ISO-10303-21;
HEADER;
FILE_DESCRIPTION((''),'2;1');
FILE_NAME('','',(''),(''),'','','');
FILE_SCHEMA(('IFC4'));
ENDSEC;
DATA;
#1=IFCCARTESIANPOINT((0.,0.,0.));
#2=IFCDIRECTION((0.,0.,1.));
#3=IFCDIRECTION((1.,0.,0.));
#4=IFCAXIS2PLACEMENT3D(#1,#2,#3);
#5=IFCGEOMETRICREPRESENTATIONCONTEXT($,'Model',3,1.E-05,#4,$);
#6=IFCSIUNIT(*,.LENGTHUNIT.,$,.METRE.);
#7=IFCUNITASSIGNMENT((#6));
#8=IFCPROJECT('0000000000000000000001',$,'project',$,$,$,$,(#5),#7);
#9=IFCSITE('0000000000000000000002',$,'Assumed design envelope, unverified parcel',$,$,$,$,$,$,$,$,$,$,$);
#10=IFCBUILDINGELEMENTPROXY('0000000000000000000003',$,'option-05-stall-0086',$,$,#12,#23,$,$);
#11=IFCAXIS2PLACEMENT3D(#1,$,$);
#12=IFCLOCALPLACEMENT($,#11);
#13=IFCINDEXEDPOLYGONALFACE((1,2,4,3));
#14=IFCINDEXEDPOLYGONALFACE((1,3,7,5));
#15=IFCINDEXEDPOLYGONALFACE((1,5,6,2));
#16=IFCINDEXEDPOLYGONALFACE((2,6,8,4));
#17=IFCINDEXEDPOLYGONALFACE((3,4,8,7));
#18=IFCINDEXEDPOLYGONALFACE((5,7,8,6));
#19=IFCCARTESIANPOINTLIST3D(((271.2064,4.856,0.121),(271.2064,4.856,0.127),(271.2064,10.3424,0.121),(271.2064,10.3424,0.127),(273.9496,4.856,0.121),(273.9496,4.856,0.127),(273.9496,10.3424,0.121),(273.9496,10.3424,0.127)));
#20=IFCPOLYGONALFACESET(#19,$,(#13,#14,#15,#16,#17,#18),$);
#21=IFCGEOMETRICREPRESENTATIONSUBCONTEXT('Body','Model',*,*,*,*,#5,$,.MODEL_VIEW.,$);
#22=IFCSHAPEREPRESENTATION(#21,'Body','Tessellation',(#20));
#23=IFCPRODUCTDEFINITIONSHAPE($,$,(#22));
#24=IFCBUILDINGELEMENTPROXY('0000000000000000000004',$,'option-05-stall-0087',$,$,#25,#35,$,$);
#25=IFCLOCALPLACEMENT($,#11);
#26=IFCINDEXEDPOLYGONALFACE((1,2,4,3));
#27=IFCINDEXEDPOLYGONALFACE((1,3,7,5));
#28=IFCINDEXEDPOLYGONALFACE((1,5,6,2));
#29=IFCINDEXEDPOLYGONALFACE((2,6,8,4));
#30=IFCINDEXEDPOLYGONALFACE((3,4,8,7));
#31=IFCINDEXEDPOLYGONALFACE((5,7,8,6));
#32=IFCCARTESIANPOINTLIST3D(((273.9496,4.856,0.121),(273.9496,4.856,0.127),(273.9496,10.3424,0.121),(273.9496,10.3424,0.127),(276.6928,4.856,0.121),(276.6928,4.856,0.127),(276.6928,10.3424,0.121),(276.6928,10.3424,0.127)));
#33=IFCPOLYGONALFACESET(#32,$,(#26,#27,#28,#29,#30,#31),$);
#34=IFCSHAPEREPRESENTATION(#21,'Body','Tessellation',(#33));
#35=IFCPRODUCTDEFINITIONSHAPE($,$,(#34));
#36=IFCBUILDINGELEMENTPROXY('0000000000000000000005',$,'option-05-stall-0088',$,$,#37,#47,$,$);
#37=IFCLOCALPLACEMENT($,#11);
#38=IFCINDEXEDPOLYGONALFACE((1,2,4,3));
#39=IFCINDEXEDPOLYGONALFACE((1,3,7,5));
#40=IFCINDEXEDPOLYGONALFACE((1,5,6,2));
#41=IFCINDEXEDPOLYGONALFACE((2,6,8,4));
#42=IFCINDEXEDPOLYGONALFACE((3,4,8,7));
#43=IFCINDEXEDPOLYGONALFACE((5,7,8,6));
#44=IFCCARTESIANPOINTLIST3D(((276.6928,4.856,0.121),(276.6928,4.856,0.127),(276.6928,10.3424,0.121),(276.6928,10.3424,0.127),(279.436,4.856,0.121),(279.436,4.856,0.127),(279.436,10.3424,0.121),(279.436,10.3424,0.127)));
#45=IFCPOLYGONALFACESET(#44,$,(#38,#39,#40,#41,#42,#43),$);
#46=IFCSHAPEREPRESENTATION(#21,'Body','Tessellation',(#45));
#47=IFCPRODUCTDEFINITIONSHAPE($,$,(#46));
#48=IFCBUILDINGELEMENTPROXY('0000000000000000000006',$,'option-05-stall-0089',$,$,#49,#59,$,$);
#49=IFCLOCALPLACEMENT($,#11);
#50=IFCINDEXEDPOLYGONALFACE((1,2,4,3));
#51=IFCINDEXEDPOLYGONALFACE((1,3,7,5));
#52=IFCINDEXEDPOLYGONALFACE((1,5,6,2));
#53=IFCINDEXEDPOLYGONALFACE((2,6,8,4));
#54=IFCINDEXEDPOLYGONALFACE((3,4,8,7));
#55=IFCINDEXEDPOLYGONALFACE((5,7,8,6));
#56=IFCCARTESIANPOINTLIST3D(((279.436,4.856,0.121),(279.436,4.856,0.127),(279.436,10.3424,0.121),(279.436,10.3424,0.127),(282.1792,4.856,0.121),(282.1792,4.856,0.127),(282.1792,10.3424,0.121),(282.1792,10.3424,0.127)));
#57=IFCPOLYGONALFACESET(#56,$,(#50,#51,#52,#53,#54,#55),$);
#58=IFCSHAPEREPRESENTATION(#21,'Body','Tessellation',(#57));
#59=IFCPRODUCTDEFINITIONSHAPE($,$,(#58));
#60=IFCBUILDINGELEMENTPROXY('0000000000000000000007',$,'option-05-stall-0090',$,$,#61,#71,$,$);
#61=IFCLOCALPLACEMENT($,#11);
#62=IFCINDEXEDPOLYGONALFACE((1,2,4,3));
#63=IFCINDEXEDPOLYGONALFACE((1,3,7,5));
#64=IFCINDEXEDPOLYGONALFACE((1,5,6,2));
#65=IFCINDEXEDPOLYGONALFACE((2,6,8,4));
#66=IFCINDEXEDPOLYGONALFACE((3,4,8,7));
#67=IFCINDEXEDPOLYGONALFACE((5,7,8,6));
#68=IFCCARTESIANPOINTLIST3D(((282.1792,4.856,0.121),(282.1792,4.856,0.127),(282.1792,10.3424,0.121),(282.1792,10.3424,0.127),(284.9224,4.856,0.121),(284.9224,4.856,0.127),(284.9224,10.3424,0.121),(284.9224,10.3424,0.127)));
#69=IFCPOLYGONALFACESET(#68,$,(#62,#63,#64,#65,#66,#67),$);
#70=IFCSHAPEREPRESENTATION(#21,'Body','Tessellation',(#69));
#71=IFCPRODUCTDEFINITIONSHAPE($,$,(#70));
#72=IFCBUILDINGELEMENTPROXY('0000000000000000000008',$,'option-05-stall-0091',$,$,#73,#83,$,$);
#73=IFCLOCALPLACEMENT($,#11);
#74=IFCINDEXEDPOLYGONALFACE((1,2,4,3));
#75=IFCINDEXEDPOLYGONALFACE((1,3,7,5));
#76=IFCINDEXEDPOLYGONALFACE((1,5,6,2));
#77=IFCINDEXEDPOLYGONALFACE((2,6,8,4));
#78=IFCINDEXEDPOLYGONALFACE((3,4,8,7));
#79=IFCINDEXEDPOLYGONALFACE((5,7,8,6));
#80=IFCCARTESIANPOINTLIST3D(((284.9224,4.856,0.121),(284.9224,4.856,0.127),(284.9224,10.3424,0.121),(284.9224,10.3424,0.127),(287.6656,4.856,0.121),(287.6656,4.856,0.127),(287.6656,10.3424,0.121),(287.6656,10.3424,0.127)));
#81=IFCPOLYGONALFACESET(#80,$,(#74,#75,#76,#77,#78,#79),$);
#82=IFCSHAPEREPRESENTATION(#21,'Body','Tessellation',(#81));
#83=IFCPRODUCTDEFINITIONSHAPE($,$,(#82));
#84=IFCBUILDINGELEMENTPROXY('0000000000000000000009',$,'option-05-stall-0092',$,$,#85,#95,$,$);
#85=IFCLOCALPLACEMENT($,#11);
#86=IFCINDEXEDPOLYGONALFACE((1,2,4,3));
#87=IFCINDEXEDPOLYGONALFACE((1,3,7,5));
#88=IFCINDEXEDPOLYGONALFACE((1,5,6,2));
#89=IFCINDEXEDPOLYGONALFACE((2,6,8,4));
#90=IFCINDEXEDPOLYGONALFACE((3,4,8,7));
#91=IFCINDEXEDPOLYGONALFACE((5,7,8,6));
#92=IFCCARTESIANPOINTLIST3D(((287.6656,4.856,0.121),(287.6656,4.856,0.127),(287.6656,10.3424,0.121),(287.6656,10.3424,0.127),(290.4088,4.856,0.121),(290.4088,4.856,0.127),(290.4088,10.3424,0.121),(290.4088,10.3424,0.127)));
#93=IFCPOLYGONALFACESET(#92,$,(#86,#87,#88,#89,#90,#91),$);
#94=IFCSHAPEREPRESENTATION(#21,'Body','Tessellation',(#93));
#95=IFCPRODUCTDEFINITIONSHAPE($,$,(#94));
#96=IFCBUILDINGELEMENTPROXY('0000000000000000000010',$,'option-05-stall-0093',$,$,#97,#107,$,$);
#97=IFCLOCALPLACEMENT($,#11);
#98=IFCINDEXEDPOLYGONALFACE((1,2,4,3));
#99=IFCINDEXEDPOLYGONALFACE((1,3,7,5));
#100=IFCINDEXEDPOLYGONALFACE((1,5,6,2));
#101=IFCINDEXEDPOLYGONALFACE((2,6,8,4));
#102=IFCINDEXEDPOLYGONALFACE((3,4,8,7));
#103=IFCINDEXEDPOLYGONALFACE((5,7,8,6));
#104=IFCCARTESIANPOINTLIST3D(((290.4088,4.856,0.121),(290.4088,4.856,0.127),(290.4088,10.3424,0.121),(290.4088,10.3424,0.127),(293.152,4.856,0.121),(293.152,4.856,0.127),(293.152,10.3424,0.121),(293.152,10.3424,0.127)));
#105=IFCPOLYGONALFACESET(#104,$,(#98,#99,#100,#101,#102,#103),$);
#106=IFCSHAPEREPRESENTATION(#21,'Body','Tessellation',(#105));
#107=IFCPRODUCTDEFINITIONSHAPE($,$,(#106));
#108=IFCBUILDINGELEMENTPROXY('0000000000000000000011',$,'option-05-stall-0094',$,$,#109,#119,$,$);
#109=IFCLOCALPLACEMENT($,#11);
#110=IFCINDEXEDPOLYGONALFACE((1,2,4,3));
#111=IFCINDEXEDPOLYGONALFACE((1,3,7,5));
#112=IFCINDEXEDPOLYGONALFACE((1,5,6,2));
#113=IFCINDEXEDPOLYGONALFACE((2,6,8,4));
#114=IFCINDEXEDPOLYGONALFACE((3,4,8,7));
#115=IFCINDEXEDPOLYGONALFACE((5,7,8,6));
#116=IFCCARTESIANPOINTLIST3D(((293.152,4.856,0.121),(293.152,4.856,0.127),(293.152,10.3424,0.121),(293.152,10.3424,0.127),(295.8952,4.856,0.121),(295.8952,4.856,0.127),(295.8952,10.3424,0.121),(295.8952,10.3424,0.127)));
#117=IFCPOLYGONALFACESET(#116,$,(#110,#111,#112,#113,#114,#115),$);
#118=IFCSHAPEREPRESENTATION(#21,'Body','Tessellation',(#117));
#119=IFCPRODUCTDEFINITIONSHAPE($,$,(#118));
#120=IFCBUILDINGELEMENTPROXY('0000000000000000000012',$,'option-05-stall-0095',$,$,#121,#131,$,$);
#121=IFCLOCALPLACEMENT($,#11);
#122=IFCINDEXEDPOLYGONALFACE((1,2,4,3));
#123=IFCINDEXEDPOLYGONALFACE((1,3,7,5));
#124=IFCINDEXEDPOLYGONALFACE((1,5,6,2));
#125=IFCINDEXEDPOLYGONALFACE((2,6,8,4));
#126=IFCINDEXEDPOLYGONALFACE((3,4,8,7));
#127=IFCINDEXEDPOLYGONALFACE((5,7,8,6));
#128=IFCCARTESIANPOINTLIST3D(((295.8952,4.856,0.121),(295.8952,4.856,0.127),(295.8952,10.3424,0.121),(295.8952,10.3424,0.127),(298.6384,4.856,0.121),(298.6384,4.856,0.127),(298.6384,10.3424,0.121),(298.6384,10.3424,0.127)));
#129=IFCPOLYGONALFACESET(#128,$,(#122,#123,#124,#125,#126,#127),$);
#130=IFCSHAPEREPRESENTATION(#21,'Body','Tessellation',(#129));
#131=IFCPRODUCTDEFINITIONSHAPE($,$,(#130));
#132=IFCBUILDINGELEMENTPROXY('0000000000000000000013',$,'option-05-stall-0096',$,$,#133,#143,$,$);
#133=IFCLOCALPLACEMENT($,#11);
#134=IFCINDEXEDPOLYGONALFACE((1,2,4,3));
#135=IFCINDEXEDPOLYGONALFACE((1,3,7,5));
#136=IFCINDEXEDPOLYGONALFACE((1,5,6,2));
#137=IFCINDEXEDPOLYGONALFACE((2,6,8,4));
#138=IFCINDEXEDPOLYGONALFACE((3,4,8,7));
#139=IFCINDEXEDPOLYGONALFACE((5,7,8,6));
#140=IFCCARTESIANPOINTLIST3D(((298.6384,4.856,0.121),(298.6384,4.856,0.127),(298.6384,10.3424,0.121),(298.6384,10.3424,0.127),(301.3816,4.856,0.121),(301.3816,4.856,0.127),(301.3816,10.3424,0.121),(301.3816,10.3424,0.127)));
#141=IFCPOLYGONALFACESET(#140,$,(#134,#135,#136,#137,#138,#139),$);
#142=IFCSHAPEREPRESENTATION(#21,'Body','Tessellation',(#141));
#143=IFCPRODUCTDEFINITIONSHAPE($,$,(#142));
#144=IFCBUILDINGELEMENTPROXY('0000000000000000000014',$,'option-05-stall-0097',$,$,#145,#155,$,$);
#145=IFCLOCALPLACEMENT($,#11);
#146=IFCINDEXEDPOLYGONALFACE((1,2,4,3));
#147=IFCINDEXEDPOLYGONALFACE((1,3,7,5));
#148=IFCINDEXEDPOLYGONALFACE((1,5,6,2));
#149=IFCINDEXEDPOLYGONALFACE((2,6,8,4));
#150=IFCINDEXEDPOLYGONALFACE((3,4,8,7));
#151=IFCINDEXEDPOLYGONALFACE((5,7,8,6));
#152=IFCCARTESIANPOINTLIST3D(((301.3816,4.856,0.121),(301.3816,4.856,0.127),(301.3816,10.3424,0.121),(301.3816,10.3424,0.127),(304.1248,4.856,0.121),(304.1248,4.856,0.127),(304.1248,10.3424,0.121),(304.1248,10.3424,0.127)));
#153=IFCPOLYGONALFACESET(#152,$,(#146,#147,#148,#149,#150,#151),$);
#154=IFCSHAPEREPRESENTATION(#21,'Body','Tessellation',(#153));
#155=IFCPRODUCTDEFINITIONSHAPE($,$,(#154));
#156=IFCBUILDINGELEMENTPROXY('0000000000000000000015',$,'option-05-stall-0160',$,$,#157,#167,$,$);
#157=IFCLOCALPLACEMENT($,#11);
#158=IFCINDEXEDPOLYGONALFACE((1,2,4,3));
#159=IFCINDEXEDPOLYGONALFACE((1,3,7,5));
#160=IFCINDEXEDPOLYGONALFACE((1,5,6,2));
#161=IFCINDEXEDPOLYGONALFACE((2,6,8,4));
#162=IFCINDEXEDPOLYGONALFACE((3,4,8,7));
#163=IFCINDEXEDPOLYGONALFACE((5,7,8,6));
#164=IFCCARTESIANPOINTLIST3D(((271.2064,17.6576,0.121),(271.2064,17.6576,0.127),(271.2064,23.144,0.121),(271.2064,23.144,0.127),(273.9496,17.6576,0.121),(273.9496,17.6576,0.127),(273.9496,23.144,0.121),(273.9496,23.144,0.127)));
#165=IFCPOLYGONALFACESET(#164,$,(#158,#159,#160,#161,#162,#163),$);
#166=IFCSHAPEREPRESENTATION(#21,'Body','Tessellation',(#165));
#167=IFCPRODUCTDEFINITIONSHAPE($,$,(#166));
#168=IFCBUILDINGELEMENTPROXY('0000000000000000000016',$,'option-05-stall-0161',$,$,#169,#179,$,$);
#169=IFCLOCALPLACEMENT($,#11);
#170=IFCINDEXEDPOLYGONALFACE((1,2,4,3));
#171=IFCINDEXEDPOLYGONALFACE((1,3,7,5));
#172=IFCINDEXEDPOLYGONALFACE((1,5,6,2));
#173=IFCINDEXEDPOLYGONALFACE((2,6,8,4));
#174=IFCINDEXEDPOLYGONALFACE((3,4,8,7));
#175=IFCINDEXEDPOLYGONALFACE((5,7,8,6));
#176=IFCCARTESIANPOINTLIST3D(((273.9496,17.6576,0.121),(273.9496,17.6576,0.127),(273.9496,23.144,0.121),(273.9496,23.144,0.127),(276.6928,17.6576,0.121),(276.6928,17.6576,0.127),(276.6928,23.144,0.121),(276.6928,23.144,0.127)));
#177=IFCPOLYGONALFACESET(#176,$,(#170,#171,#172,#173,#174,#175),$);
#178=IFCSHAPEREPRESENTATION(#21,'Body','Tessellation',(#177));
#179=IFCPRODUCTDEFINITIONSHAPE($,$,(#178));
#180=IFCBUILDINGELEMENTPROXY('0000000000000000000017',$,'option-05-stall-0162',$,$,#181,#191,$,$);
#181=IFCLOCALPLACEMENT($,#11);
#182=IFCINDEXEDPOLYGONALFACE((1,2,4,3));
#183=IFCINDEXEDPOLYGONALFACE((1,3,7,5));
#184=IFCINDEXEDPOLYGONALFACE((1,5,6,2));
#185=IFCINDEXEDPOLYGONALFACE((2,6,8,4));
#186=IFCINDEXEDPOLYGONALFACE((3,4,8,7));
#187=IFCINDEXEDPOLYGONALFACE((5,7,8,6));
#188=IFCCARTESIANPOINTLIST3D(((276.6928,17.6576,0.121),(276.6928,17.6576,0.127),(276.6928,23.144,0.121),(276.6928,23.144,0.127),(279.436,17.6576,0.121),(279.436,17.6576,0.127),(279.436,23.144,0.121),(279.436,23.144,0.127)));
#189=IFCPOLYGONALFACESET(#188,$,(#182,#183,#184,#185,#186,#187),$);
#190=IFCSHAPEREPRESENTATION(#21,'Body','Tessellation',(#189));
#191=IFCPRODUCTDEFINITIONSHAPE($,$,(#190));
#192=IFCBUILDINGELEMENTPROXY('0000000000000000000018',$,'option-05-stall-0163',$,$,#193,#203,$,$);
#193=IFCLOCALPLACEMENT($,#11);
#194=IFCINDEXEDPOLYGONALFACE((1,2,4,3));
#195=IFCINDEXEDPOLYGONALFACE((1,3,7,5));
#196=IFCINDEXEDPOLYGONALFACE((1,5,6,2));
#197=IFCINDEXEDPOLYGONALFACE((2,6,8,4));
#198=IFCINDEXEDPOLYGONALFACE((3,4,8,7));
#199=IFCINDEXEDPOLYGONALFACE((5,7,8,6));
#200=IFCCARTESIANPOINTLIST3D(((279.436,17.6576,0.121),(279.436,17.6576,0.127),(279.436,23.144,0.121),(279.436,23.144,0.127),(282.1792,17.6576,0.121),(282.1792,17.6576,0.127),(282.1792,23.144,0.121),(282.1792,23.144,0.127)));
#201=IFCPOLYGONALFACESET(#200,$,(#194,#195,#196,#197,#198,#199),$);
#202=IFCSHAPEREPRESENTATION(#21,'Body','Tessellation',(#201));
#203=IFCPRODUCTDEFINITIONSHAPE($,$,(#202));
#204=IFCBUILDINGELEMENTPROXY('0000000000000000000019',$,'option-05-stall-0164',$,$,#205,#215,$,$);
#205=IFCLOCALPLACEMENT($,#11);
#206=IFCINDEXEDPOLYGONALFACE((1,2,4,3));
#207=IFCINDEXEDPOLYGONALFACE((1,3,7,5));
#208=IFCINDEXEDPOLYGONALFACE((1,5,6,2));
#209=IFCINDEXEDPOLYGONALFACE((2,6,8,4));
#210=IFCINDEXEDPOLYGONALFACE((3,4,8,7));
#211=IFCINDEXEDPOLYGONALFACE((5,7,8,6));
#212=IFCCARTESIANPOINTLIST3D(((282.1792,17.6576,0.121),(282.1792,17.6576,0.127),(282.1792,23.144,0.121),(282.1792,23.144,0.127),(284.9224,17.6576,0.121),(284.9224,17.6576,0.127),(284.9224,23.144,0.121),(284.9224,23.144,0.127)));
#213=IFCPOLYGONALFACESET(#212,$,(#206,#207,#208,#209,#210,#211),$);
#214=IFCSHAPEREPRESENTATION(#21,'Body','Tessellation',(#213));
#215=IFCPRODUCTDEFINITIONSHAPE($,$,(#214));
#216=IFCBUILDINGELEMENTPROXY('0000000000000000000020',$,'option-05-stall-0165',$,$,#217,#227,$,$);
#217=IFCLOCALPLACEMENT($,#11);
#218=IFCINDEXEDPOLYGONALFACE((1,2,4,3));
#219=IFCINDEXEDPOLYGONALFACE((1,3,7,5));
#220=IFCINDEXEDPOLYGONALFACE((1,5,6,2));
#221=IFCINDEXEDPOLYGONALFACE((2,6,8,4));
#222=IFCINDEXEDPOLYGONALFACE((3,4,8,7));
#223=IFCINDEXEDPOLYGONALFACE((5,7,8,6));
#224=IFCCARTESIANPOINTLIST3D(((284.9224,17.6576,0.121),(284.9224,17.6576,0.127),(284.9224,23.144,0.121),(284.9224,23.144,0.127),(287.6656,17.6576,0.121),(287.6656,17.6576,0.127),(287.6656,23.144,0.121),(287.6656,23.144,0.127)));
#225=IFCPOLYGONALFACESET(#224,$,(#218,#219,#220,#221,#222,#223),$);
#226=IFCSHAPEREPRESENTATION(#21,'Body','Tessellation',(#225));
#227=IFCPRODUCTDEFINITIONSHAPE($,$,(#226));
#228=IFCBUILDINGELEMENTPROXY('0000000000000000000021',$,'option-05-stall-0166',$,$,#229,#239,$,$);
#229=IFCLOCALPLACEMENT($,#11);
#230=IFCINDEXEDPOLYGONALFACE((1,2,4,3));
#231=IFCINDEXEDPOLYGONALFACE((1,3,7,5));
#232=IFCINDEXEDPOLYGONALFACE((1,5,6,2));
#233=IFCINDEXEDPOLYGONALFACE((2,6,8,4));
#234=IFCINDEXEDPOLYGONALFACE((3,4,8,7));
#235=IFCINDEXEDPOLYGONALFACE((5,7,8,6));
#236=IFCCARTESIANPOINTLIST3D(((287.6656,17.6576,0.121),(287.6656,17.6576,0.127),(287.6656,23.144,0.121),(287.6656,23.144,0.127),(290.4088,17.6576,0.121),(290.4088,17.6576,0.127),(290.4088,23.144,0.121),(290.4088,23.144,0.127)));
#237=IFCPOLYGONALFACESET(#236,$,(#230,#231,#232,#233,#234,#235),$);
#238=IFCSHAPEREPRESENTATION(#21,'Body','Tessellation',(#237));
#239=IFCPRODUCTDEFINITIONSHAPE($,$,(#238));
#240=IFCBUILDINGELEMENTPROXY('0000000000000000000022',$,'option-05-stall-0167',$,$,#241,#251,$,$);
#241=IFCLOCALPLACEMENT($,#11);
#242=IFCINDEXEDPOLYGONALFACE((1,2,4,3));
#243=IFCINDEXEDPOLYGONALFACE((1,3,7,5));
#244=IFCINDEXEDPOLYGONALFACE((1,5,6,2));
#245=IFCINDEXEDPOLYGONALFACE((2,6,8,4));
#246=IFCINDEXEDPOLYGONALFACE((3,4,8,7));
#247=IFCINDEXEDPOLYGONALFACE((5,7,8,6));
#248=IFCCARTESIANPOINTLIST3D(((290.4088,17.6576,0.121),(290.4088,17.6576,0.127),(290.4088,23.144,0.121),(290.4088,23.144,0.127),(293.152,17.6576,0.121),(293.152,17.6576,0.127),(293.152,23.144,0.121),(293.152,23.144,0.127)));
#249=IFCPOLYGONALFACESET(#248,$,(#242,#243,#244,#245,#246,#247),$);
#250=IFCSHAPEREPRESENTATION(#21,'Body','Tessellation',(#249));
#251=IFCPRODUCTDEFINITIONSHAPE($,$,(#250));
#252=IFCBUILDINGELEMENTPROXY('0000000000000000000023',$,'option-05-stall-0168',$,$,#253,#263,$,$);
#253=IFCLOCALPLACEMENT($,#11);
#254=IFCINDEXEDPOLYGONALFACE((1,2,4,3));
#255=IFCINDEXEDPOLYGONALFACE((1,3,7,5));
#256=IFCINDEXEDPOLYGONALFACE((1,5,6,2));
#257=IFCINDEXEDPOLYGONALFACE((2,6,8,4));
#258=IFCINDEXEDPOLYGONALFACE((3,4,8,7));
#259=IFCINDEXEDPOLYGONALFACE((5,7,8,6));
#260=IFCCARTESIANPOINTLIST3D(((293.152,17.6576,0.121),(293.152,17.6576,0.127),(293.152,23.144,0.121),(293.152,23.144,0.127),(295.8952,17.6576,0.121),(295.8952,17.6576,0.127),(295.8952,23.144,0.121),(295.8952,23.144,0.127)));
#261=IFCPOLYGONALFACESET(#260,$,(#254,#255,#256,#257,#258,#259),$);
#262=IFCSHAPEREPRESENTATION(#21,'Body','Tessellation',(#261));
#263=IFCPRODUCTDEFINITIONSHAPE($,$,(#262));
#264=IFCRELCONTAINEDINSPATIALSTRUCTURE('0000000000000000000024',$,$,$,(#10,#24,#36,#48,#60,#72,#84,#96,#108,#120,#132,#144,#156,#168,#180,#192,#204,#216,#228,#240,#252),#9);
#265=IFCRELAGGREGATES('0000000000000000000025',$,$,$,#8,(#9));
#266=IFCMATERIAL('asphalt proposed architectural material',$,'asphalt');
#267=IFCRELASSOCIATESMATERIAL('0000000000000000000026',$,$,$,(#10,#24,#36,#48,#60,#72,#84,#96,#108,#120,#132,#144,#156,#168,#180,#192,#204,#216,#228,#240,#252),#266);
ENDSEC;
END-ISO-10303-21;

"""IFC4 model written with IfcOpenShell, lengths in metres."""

from ifc_helpers import new_model, si_unit, frame, origin_with_axes, place, context, subcontext, project, spatial, rectangle, extrude, material, element, save


model = new_model("IFC4")

# Units and contexts
model_context = context("Model", 3, precision=1e-05, world=origin_with_axes())
body_context = subcontext(model_context, "Body", "Model", "MODEL_VIEW")
ifc_project = project(units=[si_unit("LENGTHUNIT", "METRE")], contexts=[model_context])

# Site
site = spatial("IfcSite", under=ifc_project, Name="Assumed design envelope, unverified parcel")

# Building element proxies
ifc_material = material(Name="asphalt proposed architectural material", Category="asphalt")
for number, where, z_axis, x_axis, name in (
    (1, (272.578, 7.5992, 0.121), (0.0, 0.0, 1.0), (1.0, 0.0, 0.0), "option-05-stall-0086"),
    (2, (275.3212, 7.5992, 0.121), (0.0, 0.0, 1.0), (1.0, 0.0, 0.0), "option-05-stall-0087"),
    (3, (278.0644, 7.5992, 0.121), (0.0, 0.0, 1.0), (1.0, 0.0, 0.0), "option-05-stall-0088"),
    (4, (280.8076, 7.5992, 0.121), (0.0, 0.0, 1.0), (1.0, 0.0, 0.0), "option-05-stall-0089"),
    (5, (283.5508, 7.5992, 0.121), (0.0, 0.0, 1.0), (1.0, 0.0, 0.0), "option-05-stall-0090"),
    (6, (286.294, 7.5992, 0.121), (0.0, 0.0, 1.0), (1.0, 0.0, 0.0), "option-05-stall-0091"),
    (7, (289.0372, 7.5992, 0.121), (0.0, 0.0, 1.0), (1.0, 0.0, 0.0), "option-05-stall-0092"),
    (8, (291.7804, 7.5992, 0.121), (0.0, 0.0, 1.0), (1.0, 0.0, 0.0), "option-05-stall-0093"),
    (9, (294.5236, 7.5992, 0.121), (0.0, 0.0, 1.0), (1.0, 0.0, 0.0), "option-05-stall-0094"),
    (10, (297.2668, 7.5992, 0.121), (0.0, 0.0, 1.0), (1.0, 0.0, 0.0), "option-05-stall-0095"),
    (11, (300.01, 7.5992, 0.121), (0.0, 0.0, 1.0), (1.0, 0.0, 0.0), "option-05-stall-0096"),
    (12, (302.7532, 7.5992, 0.121), (0.0, 0.0, 1.0), (1.0, 0.0, 0.0), "option-05-stall-0097"),
):
    element("IfcBuildingElementProxy", number, at=place(None, frame(where, z_axis=z_axis, x_axis=x_axis)), inside=site, material=ifc_material, Name=name, context=body_context, shape_type="SweptSolid", body=[
        extrude(rectangle(XDim=2.7432, YDim=5.4864), origin_with_axes(), (0.0, 0.0, 1.0), 0.006),
    ])
for number, where, z_axis, x_axis, name in (
    (13, (272.578, 20.4008, 0.121), (0.0, 0.0, 1.0), (1.0, 0.0, 0.0), "option-05-stall-0160"),
    (14, (275.3212, 20.4008, 0.121), (0.0, 0.0, 1.0), (1.0, 0.0, 0.0), "option-05-stall-0161"),
    (15, (278.0644, 20.4008, 0.121), (0.0, 0.0, 1.0), (1.0, 0.0, 0.0), "option-05-stall-0162"),
    (16, (280.8076, 20.4008, 0.121), (0.0, 0.0, 1.0), (1.0, 0.0, 0.0), "option-05-stall-0163"),
    (17, (283.5508, 20.4008, 0.121), (0.0, 0.0, 1.0), (1.0, 0.0, 0.0), "option-05-stall-0164"),
    (18, (286.294, 20.4008, 0.121), (0.0, 0.0, 1.0), (1.0, 0.0, 0.0), "option-05-stall-0165"),
    (19, (289.0372, 20.4008, 0.121), (0.0, 0.0, 1.0), (1.0, 0.0, 0.0), "option-05-stall-0166"),
    (20, (291.7804, 20.4008, 0.121), (0.0, 0.0, 1.0), (1.0, 0.0, 0.0), "option-05-stall-0167"),
    (21, (294.5236, 20.4008, 0.121), (0.0, 0.0, 1.0), (1.0, 0.0, 0.0), "option-05-stall-0168"),
):
    element("IfcBuildingElementProxy", number, at=place(None, frame(where, z_axis=z_axis, x_axis=x_axis)), inside=site, material=ifc_material, Name=name, context=body_context, shape_type="SweptSolid", body=[
        extrude(rectangle(XDim=2.7432, YDim=5.4864), origin_with_axes(), (0.0, 0.0, 1.0), 0.006),
    ])

save(model, "model.ifc")
